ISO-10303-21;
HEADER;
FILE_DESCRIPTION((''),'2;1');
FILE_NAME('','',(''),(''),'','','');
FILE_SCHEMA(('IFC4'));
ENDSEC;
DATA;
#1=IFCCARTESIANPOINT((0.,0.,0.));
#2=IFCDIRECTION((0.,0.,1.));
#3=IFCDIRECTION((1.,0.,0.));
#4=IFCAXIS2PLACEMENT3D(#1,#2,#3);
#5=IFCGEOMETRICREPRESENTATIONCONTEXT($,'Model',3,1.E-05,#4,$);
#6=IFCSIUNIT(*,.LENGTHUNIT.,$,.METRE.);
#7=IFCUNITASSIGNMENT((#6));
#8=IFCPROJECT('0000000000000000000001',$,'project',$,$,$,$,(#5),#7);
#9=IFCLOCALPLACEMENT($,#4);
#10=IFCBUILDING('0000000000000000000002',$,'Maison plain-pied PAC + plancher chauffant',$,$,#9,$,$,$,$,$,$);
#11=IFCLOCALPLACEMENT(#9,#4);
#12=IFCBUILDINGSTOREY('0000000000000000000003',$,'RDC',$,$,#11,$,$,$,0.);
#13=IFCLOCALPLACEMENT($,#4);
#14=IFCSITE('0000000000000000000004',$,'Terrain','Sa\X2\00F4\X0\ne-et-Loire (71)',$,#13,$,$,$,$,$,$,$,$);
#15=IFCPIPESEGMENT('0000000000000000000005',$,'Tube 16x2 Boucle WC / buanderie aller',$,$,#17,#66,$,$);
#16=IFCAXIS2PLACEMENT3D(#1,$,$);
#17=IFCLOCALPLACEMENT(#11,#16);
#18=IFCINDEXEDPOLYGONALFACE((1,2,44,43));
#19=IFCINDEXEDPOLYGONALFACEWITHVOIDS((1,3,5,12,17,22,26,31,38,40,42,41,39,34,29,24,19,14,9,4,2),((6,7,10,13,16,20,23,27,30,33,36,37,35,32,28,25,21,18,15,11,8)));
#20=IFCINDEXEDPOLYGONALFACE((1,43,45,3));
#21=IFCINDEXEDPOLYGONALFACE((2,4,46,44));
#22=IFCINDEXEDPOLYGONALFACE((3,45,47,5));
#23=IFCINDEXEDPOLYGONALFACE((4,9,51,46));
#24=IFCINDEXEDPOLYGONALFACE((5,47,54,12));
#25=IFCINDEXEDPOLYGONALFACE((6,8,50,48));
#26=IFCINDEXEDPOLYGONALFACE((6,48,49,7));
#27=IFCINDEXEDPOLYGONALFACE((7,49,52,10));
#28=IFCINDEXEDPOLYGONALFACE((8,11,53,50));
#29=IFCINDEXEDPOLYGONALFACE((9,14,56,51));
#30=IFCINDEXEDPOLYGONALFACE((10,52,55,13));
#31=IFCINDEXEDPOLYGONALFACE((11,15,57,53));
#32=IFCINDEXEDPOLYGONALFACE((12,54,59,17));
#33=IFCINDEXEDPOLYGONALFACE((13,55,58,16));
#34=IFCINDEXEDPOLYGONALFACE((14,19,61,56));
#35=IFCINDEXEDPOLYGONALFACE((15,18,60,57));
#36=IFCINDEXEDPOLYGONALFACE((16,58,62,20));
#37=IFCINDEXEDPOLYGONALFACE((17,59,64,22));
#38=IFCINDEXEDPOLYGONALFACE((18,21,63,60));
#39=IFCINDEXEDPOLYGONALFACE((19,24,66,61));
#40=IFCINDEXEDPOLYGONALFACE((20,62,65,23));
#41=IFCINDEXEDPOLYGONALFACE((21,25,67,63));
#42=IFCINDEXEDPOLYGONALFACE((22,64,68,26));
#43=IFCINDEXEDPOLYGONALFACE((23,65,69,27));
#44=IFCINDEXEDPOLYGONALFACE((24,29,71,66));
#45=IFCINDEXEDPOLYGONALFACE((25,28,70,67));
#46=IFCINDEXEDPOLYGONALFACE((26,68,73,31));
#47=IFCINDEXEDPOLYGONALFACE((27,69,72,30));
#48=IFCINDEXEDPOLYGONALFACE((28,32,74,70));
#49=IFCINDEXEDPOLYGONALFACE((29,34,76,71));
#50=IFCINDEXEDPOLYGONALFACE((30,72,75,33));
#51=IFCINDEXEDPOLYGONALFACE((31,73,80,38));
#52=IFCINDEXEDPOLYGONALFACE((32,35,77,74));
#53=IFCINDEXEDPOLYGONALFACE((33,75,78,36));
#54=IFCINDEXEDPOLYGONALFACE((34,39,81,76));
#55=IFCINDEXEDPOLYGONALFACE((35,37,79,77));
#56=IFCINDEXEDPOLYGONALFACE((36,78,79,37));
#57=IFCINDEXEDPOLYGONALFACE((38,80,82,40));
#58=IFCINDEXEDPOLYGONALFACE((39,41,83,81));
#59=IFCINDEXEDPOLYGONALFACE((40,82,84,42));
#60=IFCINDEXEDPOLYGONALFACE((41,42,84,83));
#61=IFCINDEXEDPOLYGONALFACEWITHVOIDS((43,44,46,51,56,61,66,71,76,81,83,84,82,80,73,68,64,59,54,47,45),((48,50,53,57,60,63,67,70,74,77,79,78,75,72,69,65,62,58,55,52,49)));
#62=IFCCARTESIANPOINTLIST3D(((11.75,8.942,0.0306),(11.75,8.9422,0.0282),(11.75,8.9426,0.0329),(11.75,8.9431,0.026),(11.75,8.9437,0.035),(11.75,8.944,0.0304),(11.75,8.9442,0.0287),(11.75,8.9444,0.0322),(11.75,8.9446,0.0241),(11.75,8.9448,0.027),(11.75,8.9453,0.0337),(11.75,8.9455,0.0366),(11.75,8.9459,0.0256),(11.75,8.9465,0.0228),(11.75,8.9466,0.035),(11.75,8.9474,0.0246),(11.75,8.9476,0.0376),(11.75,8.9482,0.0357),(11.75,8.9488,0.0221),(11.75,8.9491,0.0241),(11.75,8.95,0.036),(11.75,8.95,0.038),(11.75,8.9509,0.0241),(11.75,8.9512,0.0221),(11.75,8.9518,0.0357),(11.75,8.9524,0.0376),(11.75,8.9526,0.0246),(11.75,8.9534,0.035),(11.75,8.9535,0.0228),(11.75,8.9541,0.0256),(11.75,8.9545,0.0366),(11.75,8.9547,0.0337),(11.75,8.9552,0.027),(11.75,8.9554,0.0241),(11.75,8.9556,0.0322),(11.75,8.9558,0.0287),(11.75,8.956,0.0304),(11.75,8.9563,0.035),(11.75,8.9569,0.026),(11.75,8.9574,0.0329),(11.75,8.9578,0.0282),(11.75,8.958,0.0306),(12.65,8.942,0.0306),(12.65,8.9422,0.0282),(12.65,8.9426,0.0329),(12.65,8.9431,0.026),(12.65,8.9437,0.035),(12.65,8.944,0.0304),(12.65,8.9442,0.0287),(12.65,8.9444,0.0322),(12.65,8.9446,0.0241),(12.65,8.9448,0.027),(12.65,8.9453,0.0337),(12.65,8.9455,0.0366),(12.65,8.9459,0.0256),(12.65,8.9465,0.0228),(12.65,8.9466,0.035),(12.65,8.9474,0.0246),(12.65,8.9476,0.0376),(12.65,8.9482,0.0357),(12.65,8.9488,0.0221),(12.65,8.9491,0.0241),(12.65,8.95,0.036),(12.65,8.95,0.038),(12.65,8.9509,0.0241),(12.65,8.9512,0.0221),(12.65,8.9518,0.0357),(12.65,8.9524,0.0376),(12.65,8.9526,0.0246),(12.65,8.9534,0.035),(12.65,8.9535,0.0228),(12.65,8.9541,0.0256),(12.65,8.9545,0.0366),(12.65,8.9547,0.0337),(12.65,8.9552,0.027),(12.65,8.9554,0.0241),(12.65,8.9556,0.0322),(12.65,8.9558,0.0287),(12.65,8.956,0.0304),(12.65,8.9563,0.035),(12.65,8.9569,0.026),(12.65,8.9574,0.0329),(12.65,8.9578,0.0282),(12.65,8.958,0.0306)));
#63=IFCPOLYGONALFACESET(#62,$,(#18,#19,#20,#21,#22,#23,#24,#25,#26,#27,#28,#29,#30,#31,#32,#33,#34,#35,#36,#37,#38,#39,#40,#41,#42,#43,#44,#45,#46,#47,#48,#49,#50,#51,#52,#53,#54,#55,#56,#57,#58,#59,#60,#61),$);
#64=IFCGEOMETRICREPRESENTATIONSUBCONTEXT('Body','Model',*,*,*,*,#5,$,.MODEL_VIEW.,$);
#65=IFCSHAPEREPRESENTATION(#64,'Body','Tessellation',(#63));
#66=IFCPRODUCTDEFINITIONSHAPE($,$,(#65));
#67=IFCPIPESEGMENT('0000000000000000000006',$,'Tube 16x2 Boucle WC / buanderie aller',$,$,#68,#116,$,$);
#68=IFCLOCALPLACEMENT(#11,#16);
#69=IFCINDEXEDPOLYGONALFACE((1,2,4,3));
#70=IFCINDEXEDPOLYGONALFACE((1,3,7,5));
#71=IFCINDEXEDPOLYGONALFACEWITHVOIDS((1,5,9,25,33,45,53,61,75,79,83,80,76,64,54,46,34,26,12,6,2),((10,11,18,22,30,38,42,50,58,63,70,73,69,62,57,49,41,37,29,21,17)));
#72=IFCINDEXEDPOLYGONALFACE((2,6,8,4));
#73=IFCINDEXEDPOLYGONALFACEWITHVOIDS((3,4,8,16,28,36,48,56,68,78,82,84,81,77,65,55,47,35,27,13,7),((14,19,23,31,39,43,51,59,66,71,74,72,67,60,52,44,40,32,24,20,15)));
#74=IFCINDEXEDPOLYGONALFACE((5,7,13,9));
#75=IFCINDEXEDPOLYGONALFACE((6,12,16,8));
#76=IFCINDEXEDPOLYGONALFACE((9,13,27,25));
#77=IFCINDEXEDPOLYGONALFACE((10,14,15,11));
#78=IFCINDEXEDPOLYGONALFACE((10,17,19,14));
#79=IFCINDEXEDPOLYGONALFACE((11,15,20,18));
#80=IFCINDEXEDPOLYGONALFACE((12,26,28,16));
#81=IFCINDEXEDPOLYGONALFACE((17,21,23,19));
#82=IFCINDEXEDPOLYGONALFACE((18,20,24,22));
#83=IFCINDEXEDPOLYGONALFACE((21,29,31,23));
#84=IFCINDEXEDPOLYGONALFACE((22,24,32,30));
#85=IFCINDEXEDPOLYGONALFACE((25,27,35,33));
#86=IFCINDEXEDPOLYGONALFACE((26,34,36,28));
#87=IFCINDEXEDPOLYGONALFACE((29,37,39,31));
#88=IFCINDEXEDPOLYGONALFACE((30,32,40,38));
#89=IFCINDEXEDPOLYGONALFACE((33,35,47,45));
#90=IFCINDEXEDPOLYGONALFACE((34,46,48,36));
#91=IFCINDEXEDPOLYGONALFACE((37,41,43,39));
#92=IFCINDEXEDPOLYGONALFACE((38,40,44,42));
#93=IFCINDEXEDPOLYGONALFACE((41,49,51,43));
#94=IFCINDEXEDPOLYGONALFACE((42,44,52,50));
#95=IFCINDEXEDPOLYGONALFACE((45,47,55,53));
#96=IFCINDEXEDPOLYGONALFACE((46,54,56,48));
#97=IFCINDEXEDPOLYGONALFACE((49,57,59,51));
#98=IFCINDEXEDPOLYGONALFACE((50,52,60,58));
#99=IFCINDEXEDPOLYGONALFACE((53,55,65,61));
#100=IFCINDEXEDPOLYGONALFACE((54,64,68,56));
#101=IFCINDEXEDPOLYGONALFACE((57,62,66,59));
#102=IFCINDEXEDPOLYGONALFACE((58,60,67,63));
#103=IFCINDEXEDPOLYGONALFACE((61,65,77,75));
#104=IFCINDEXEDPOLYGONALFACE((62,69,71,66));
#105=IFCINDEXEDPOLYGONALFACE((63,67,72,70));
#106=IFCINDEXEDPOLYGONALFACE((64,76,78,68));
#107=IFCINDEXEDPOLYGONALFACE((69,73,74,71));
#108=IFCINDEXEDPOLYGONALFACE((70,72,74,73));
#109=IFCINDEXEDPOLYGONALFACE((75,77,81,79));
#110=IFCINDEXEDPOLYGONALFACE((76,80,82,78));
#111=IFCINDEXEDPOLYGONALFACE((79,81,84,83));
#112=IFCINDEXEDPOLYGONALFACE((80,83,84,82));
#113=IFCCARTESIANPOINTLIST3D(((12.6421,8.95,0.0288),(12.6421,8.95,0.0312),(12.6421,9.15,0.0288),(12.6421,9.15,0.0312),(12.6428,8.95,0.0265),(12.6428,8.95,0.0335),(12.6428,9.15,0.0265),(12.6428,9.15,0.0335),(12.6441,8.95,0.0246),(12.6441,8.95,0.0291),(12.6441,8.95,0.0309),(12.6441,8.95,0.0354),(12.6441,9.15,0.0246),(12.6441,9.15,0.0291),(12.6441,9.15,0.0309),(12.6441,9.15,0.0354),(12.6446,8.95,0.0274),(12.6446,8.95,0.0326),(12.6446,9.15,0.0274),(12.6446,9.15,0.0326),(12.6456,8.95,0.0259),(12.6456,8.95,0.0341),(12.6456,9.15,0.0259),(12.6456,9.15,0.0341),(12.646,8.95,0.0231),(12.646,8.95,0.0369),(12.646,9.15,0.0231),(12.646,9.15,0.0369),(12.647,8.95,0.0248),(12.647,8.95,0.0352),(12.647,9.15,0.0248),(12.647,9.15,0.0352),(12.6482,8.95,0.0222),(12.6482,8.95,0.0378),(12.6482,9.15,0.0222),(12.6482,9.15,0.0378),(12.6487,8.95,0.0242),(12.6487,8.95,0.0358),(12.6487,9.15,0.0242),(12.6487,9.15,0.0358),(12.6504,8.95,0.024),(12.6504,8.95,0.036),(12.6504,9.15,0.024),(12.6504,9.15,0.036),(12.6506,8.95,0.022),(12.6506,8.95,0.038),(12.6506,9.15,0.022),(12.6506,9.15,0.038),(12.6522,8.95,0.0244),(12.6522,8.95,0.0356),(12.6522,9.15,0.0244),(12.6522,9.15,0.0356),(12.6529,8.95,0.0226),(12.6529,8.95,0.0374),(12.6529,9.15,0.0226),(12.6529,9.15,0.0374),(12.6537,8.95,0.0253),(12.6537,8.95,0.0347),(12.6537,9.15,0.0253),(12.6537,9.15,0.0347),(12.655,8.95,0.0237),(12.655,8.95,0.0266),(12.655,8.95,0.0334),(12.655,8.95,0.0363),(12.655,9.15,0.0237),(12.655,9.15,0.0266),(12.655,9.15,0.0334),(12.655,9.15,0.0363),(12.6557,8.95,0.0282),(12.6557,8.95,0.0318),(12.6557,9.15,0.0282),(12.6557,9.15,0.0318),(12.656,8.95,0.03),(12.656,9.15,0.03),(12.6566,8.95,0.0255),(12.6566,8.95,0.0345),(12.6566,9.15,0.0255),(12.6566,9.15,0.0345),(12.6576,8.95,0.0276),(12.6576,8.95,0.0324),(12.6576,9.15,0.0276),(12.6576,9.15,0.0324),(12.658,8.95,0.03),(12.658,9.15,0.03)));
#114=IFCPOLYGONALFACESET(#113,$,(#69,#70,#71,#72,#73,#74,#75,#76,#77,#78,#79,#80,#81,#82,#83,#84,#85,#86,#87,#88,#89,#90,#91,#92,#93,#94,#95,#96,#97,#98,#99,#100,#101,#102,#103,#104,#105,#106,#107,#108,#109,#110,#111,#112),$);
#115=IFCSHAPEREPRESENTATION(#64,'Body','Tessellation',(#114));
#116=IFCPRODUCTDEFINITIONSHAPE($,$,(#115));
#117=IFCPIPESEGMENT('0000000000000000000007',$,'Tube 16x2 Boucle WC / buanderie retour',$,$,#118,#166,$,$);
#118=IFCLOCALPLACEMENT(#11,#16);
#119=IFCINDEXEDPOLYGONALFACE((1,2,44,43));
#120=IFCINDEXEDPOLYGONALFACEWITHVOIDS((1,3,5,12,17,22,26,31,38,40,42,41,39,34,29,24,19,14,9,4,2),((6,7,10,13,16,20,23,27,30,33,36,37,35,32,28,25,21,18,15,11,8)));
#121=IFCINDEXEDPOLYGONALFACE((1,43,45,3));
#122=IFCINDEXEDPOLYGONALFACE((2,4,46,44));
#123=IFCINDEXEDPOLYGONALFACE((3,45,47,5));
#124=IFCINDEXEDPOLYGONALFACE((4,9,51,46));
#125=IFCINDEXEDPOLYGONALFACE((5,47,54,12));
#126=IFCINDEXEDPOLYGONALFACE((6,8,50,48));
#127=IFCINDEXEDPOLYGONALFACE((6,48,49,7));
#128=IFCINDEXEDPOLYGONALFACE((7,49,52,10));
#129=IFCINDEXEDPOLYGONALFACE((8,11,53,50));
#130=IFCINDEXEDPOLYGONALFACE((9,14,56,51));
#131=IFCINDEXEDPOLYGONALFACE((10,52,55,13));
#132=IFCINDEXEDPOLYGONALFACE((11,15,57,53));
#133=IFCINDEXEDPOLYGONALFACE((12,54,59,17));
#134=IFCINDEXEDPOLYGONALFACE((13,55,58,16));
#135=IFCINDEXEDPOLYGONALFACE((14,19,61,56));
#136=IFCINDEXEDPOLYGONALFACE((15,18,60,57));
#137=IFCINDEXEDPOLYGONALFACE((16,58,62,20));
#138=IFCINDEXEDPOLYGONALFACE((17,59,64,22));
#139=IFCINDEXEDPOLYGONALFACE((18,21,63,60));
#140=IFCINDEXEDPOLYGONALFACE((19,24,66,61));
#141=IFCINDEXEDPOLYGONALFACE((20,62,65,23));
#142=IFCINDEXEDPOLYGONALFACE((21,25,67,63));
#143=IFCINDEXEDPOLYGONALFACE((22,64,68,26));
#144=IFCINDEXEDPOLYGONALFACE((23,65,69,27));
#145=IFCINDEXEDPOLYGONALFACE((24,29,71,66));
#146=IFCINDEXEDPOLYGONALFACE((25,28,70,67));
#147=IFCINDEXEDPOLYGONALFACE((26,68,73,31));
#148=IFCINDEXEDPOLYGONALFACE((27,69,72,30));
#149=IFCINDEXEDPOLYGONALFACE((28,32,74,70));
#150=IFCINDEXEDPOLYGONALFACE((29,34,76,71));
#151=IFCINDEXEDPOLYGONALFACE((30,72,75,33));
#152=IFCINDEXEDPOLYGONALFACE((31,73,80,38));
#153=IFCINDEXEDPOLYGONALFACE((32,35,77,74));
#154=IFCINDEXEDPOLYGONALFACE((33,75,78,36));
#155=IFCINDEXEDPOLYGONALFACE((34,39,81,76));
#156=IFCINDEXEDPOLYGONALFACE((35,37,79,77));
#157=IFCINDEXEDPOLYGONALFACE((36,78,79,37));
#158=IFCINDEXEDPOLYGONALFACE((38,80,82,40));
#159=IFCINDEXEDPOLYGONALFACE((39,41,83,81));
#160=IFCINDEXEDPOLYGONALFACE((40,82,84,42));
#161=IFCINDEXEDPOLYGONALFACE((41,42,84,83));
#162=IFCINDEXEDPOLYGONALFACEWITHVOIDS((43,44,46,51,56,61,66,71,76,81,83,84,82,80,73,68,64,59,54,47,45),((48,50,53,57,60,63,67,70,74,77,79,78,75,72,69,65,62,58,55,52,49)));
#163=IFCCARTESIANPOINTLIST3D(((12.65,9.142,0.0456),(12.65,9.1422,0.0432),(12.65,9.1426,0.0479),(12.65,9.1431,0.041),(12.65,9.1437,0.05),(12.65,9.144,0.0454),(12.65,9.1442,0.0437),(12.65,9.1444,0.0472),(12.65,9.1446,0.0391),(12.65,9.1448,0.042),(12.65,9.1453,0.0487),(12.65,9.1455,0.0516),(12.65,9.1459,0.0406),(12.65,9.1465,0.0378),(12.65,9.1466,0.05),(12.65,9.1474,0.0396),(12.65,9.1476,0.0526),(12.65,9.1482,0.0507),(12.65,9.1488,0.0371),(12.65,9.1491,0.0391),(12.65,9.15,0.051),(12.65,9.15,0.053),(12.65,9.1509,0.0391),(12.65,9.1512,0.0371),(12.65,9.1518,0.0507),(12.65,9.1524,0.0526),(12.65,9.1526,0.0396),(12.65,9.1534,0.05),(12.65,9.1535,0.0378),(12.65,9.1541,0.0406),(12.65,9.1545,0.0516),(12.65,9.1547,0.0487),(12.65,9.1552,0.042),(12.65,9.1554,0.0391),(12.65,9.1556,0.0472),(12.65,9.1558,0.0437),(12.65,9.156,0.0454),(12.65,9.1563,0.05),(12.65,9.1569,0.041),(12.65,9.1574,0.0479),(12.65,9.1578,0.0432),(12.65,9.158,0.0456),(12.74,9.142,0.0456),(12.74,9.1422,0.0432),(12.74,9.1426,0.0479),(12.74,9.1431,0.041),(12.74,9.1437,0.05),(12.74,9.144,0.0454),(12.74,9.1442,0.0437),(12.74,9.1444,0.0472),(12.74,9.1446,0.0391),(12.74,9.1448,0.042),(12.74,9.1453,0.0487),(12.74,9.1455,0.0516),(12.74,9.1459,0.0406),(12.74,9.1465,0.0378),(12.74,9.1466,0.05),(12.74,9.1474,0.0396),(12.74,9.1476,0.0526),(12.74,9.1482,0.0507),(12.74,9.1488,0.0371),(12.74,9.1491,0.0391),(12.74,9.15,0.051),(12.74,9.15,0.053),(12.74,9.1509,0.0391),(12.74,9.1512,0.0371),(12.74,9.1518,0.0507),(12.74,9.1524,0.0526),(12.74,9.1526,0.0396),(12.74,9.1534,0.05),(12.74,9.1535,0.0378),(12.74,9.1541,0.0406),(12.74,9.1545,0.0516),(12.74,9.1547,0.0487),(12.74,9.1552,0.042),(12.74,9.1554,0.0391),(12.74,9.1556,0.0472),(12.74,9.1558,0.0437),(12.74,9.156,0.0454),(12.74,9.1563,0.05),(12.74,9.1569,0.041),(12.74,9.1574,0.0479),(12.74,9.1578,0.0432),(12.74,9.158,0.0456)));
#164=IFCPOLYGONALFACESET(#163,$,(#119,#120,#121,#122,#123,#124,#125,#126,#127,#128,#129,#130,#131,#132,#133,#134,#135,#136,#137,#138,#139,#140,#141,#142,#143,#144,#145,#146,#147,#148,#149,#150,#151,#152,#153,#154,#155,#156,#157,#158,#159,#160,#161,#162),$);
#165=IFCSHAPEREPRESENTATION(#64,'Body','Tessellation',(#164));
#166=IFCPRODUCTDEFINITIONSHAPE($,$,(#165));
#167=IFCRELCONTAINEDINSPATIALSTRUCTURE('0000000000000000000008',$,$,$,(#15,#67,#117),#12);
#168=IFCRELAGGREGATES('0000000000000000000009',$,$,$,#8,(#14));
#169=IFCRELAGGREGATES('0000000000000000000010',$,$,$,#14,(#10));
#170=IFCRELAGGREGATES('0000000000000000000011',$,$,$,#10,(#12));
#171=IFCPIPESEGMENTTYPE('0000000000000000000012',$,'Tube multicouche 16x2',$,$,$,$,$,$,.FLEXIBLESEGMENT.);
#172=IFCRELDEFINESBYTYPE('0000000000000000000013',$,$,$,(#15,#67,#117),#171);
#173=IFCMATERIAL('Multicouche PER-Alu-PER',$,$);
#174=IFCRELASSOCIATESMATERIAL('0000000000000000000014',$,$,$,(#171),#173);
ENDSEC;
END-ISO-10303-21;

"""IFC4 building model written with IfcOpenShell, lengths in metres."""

from ifc_helpers import new_model, si_unit, frame, origin_with_axes, place, context, subcontext, project, spatial, hollow_circle, extrude, material, type_object, element, save


model = new_model("IFC4")

# Units and contexts
model_context = context("Model", 3, precision=1e-05, world=origin_with_axes())
body_context = subcontext(model_context, "Body", "Model", "MODEL_VIEW")
ifc_project = project(units=[si_unit("LENGTHUNIT", "METRE")], contexts=[model_context])

# Site, building, storey
site_placement = place(None, origin_with_axes())
site = spatial("IfcSite", under=ifc_project, at=site_placement, Name="Terrain", Description="Saône-et-Loire (71)")
building_placement = place(None, origin_with_axes())
building = spatial("IfcBuilding", under=site, at=building_placement, Name="Maison plain-pied PAC + plancher chauffant")
storey_placement = place(building_placement, origin_with_axes())
storey = spatial("IfcBuildingStorey", under=building, at=storey_placement, Name="RDC", Elevation=0.0)

# Pipe segments
ifc_material_1 = material(Name="Multicouche PER-Alu-PER")
pipe_segment_type_1 = type_object("IfcPipeSegmentType", Name="Tube multicouche 16x2", PredefinedType="FLEXIBLESEGMENT", material=ifc_material_1)
for number, where, z_axis, x_axis, name in (
    (1, (11.75, 8.95, 0.03), (1.0, 0.0, 0.0), (0.0, 0.0, 1.0), "Tube 16x2 Boucle WC / buanderie aller"),
):
    element("IfcPipeSegment", number, at=place(storey_placement, frame(where, z_axis=z_axis, x_axis=x_axis)), inside=storey, type_object=pipe_segment_type_1, Name=name, context=body_context, shape_type="SweptSolid", body=[
        extrude(hollow_circle(Radius=0.008, WallThickness=0.002), origin_with_axes(), (0.0, 0.0, 1.0), 0.9),
    ])
pipe_segment_1_placement = place(storey_placement, frame((12.65, 8.95, 0.03), z_axis=(0.0, 1.0, 0.0), x_axis=(1.0, 0.0, 0.0)))
element("IfcPipeSegment", 2, at=pipe_segment_1_placement, inside=storey, type_object=pipe_segment_type_1, Name="Tube 16x2 Boucle WC / buanderie aller", context=body_context, shape_type="SweptSolid", body=[
    extrude(hollow_circle(Radius=0.008, WallThickness=0.002), origin_with_axes(), (0.0, 0.0, 1.0), 0.2),
])
pipe_segment_2_placement = place(storey_placement, frame((12.65, 9.15, 0.045), z_axis=(1.0, 0.0, 0.0), x_axis=(0.0, 0.0, 1.0)))
element("IfcPipeSegment", 3, at=pipe_segment_2_placement, inside=storey, type_object=pipe_segment_type_1, Name="Tube 16x2 Boucle WC / buanderie retour", context=body_context, shape_type="SweptSolid", body=[
    extrude(hollow_circle(Radius=0.008, WallThickness=0.002), origin_with_axes(), (0.0, 0.0, 1.0), 0.09),
])

save(model, "model.ifc")
